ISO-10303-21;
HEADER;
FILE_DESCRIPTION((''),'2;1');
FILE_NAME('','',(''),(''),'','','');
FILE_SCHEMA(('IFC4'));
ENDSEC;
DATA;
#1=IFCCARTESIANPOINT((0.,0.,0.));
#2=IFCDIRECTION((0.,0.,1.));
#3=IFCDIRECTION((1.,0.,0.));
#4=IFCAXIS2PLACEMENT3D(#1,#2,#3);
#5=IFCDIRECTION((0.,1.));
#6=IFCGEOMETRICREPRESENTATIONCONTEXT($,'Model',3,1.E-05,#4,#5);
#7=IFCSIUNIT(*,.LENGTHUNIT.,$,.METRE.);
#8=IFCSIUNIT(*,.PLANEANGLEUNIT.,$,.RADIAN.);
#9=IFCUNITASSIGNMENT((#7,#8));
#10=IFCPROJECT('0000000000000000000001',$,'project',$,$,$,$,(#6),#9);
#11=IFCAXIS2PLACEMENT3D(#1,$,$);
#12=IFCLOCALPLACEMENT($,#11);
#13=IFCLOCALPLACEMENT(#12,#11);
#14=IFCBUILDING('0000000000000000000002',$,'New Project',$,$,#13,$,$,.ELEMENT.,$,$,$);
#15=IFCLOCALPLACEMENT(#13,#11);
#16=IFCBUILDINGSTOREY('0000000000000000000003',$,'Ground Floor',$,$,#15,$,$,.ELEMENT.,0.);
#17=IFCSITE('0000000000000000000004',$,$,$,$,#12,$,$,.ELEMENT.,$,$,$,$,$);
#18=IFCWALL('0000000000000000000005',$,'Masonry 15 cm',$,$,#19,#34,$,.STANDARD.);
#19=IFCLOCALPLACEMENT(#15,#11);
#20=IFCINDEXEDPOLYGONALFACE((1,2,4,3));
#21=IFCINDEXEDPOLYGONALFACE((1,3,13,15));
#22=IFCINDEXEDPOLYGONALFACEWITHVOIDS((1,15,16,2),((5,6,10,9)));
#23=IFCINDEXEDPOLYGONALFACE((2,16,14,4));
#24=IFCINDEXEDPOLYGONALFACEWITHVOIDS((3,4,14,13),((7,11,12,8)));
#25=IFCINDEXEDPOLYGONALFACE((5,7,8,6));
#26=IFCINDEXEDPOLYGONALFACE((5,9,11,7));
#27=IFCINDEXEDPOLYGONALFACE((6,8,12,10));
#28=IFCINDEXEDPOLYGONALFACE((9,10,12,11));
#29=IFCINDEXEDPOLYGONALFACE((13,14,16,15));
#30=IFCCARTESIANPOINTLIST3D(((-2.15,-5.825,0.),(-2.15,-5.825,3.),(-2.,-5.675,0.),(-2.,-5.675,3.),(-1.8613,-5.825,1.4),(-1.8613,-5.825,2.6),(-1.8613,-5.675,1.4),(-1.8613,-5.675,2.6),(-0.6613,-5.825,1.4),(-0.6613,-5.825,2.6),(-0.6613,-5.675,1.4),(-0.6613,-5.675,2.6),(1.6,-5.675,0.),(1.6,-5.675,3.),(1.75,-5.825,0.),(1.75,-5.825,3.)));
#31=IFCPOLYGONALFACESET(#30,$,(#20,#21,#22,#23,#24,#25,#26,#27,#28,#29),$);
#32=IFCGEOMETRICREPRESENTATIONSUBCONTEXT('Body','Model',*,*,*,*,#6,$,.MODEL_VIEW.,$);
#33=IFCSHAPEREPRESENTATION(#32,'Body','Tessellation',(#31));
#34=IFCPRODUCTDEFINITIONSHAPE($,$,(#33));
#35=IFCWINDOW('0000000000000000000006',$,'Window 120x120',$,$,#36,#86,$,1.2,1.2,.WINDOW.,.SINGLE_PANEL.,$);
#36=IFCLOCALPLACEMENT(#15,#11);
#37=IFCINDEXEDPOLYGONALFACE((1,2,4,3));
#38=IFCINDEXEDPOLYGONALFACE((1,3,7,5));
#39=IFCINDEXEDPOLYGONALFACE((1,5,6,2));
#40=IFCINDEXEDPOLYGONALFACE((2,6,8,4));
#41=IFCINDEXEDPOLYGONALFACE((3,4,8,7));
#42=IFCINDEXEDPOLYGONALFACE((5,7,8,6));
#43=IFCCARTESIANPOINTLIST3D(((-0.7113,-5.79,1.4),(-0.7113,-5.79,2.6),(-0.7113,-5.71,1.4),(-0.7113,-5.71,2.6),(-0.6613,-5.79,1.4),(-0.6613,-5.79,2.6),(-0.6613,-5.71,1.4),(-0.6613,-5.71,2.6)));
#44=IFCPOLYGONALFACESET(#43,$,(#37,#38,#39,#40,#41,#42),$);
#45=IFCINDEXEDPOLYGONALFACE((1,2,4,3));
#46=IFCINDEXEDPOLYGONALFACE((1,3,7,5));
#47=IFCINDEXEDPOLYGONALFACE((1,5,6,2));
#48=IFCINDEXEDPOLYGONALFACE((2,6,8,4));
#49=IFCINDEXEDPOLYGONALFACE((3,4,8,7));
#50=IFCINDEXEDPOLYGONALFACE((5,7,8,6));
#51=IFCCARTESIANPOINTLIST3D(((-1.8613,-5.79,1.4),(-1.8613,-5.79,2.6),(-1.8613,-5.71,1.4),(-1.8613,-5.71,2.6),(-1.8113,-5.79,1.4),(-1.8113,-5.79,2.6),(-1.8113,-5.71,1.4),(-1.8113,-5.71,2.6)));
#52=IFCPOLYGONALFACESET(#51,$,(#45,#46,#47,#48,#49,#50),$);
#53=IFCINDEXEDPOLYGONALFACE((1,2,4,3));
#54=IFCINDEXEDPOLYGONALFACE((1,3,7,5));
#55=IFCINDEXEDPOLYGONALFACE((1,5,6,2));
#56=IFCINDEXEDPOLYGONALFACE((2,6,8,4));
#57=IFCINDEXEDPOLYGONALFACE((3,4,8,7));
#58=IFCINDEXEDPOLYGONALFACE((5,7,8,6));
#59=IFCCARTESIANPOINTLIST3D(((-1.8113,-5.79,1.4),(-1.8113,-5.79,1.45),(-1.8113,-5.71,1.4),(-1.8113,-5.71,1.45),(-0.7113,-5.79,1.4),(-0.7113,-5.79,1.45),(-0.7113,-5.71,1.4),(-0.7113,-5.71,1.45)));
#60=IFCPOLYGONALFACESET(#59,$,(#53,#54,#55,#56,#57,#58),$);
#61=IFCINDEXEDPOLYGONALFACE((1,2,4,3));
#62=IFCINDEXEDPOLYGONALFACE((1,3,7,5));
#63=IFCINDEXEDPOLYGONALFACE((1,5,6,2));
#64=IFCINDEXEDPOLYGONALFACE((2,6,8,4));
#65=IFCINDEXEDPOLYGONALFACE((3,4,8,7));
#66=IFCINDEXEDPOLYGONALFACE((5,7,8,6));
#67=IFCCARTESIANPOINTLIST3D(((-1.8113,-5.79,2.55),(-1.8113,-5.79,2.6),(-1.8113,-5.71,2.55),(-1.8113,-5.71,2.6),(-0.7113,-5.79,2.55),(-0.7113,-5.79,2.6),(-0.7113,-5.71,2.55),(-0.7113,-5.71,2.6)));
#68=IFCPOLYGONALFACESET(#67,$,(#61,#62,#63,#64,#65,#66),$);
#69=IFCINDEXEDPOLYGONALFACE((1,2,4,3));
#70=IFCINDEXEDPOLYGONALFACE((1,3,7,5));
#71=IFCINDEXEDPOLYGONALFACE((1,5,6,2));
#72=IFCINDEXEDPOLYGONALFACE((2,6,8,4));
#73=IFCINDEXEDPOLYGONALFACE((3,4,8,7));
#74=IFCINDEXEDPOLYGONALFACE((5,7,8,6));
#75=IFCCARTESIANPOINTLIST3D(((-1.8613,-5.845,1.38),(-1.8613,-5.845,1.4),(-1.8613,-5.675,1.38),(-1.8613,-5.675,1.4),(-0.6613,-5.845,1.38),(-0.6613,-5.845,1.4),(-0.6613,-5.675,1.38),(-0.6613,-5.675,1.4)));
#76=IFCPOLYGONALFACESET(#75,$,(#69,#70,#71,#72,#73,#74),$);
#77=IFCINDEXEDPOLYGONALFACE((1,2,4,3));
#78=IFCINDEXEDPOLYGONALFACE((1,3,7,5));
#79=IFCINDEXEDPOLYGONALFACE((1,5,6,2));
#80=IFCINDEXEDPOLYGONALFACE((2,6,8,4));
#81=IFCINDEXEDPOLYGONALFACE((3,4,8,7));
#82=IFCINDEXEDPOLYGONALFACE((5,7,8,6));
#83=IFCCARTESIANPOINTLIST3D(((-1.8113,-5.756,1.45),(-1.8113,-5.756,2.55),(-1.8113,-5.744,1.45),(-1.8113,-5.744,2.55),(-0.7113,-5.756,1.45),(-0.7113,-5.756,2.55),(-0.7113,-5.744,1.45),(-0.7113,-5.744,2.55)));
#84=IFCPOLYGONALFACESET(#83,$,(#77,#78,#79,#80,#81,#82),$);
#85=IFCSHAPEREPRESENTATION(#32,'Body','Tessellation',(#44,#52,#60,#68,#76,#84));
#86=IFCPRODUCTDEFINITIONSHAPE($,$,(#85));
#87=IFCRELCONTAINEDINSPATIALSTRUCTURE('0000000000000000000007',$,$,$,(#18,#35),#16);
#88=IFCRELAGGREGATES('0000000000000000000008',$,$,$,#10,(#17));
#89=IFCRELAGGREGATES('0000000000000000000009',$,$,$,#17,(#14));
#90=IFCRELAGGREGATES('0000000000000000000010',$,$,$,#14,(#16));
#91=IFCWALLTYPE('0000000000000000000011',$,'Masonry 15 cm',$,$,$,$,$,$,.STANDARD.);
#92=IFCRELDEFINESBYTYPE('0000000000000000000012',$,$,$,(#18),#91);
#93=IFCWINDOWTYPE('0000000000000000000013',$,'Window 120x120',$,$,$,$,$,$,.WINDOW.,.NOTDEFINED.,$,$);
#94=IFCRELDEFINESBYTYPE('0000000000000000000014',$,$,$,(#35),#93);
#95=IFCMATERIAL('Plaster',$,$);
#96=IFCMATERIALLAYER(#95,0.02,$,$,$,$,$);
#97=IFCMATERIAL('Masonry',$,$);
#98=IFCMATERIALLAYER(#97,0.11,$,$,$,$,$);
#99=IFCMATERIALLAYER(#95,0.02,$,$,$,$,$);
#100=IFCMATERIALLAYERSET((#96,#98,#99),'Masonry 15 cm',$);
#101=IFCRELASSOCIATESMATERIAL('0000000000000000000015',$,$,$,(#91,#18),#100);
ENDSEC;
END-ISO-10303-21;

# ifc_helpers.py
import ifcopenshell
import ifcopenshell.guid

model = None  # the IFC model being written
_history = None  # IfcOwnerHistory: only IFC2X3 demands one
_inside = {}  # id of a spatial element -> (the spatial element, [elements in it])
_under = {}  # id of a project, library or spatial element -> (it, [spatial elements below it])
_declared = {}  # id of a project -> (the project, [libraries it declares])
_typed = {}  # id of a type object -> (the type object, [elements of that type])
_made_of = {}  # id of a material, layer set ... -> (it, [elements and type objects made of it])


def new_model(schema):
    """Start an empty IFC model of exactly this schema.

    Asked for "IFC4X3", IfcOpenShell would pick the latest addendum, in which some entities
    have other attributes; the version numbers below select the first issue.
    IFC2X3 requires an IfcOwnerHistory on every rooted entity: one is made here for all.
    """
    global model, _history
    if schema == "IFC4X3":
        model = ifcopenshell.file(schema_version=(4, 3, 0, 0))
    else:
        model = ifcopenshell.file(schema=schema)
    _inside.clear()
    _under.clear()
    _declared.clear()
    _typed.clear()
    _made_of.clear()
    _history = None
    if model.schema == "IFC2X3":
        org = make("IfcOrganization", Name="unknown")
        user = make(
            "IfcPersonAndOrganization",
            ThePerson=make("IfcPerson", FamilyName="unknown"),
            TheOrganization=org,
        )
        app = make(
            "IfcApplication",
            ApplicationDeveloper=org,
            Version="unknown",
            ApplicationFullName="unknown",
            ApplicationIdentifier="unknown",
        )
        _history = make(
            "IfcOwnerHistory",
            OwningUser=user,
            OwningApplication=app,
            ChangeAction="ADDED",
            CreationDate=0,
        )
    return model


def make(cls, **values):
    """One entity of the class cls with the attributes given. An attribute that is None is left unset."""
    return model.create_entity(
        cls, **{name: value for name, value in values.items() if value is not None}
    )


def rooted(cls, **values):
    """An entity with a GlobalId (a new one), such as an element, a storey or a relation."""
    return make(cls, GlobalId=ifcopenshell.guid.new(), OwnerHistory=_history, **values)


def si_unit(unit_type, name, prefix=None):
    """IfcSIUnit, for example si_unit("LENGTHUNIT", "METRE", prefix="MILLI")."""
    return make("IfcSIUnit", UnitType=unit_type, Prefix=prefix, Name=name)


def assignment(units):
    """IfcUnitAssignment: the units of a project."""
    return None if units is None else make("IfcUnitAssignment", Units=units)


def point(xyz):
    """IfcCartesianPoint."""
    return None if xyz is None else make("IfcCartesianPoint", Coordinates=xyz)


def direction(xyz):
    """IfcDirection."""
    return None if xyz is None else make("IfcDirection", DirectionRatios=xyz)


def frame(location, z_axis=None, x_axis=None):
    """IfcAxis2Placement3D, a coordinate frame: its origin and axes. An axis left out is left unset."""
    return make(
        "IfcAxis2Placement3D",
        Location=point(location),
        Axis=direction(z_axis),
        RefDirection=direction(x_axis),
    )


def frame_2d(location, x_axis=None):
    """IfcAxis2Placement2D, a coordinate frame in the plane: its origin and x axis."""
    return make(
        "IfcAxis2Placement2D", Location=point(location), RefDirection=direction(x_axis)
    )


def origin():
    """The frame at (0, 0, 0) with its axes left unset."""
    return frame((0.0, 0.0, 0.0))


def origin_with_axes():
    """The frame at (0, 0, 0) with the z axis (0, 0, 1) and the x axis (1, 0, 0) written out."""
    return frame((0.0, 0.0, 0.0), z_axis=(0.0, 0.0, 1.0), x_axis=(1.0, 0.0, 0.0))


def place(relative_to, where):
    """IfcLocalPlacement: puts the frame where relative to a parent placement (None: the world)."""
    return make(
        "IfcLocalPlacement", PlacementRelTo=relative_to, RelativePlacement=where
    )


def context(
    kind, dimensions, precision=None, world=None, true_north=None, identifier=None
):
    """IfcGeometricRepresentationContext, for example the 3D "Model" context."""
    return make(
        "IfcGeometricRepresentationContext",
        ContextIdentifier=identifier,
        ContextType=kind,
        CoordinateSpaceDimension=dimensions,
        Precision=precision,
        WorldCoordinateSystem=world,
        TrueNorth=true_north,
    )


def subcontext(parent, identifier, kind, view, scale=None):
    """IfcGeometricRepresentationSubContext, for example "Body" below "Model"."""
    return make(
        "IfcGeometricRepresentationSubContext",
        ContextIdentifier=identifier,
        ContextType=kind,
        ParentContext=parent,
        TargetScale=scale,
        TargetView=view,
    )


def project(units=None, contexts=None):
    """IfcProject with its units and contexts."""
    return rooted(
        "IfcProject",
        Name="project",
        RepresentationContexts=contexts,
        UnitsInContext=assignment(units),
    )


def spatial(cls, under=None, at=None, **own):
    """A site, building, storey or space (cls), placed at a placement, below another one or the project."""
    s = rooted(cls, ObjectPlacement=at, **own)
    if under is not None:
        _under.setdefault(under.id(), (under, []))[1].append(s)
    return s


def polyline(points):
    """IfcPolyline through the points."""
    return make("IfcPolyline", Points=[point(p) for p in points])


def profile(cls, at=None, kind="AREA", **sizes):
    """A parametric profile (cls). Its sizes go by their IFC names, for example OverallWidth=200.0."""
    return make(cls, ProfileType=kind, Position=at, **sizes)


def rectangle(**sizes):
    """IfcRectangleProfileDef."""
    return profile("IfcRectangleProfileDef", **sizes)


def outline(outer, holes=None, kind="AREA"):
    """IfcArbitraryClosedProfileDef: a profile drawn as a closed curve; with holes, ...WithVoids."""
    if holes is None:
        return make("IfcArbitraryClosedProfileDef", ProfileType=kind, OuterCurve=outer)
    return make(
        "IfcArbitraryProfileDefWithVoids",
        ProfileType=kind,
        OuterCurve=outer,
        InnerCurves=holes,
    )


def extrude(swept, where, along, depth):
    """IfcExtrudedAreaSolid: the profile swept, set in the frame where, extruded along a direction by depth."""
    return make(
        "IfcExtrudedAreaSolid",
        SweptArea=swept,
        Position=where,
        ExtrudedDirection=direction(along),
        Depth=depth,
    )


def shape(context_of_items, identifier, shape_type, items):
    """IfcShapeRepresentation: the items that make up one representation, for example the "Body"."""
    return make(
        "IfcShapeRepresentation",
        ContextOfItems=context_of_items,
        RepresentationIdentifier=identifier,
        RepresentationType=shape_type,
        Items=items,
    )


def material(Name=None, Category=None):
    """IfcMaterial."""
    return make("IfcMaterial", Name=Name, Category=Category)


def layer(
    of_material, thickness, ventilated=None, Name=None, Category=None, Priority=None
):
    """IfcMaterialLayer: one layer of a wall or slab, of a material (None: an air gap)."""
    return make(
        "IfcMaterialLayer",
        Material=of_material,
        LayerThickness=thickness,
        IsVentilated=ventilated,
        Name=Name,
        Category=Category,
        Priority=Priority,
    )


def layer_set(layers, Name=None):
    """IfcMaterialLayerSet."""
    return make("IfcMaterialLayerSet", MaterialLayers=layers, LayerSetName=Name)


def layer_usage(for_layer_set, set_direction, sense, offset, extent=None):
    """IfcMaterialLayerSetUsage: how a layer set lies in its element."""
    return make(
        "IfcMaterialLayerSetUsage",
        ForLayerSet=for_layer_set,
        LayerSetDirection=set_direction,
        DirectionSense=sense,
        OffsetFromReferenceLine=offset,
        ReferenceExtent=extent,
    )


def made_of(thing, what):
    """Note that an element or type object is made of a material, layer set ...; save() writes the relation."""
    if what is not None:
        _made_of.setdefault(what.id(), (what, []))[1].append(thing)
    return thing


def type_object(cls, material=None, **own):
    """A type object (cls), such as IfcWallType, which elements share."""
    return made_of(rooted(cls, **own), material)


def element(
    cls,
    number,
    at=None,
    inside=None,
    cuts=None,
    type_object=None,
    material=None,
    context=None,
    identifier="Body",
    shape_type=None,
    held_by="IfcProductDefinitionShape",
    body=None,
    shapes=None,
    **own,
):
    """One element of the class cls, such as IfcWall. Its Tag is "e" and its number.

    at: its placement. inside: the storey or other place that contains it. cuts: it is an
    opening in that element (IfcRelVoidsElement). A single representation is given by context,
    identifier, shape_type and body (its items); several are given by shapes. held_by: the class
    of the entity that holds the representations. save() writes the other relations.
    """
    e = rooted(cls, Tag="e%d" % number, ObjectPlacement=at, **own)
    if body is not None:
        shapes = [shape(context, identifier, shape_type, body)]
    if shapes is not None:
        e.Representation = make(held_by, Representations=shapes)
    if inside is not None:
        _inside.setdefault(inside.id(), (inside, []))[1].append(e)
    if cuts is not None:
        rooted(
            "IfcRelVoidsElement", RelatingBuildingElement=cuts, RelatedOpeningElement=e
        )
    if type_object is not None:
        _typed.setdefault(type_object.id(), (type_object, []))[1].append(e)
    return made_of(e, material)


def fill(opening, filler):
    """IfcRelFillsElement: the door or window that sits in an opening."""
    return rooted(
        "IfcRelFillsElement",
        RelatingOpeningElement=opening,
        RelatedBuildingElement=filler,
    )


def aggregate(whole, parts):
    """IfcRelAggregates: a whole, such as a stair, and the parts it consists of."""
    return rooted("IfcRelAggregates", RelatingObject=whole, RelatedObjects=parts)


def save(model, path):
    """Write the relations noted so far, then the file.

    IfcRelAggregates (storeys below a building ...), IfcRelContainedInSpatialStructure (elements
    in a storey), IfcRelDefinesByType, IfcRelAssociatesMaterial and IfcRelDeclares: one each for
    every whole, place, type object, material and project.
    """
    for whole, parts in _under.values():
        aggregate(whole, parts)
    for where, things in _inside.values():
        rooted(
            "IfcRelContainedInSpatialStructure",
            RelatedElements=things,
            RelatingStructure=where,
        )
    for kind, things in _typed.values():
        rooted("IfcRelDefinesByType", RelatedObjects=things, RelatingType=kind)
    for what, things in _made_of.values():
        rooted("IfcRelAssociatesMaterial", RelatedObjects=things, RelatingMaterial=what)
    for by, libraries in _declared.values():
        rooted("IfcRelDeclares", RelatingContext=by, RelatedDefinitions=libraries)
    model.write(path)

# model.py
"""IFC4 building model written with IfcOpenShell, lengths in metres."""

from ifc_helpers import new_model, si_unit, direction, frame, frame_2d, origin, origin_with_axes, place, context, subcontext, project, spatial, polyline, rectangle, outline, extrude, material, layer, layer_set, layer_usage, type_object, element, fill, save


model = new_model("IFC4")

# Units and contexts
model_context = context("Model", 3, precision=1e-05, world=origin_with_axes(), true_north=direction((0.0, 1.0)))
body_context = subcontext(model_context, "Body", "Model", "MODEL_VIEW")
ifc_project = project(units=[si_unit("LENGTHUNIT", "METRE"), si_unit("PLANEANGLEUNIT", "RADIAN")], contexts=[model_context])

# Site, building, storey
site_placement = place(None, origin())
site = spatial("IfcSite", under=ifc_project, at=site_placement, CompositionType="ELEMENT")
building_placement = place(site_placement, origin())
building = spatial("IfcBuilding", under=site, at=building_placement, Name="New Project", CompositionType="ELEMENT")
storey_placement = place(building_placement, origin())
storey = spatial("IfcBuildingStorey", under=building, at=storey_placement, Name="Ground Floor", CompositionType="ELEMENT", Elevation=0.0)

# Shared definitions
ifc_material_1 = material(Name="Plaster")
ifc_layer_1 = layer(ifc_material_1, 0.02)
ifc_material_2 = material(Name="Masonry")
ifc_layer_2 = layer(ifc_material_2, 0.11)
ifc_layer_3 = layer(ifc_material_1, 0.02)
ifc_layer_set_1 = layer_set([ifc_layer_1, ifc_layer_2, ifc_layer_3], Name="Masonry 15 cm")
ifc_layer_usage_1 = layer_usage(ifc_layer_set_1, "AXIS2", "NEGATIVE", 0.075)
wall_type = type_object("IfcWallType", Name="Masonry 15 cm", PredefinedType="STANDARD", material=ifc_layer_set_1)
window_type = type_object("IfcWindowType", Name="Window 120x120", PartitioningType="NOTDEFINED", PredefinedType="WINDOW")

# Wall, opening, window
wall_1_placement = place(storey_placement, frame((1.675, -5.75, 0.0), z_axis=(0.0, 0.0, 1.0), x_axis=(-1.0, 0.0, 0.0)))
wall_1 = element("IfcWall", 1, at=wall_1_placement, inside=storey, type_object=wall_type, material=ifc_layer_usage_1, Name="Masonry 15 cm", PredefinedType="STANDARD", context=body_context, shape_type="SweptSolid", body=[
    extrude(outline(polyline([(0.075, -0.075), (3.675, -0.075), (3.825, 0.075), (-0.075, 0.075), (0.075, -0.075)])), origin(), (0.0, 0.0, 1.0), 3.0),
])
opening_1_placement = place(wall_1_placement, frame((2.3363, 0.0, 1.4)))
opening_1 = element("IfcOpeningElement", 2, at=opening_1_placement, cuts=wall_1, PredefinedType="OPENING", context=body_context, shape_type="SweptSolid", body=[
    extrude(rectangle(XDim=1.2, YDim=0.25, at=frame_2d((0.6, 0.0))), origin(), (0.0, 0.0, 1.0), 1.2),
])
window_1_placement = place(opening_1_placement, origin())
window_1 = element("IfcWindow", 3, at=window_1_placement, inside=storey, type_object=window_type, Name="Window 120x120", OverallHeight=1.2, OverallWidth=1.2, PartitioningType="SINGLE_PANEL", PredefinedType="WINDOW", context=body_context, shape_type="SweptSolid", body=[
    extrude(outline(polyline([(0.0, -0.04), (0.05, -0.04), (0.05, 0.04), (0.0, 0.04), (0.0, -0.04)])), origin(), (0.0, 0.0, 1.0), 1.2),
    extrude(outline(polyline([(1.15, -0.04), (1.2, -0.04), (1.2, 0.04), (1.15, 0.04), (1.15, -0.04)])), origin(), (0.0, 0.0, 1.0), 1.2),
    extrude(outline(polyline([(0.05, -0.04), (1.15, -0.04), (1.15, 0.04), (0.05, 0.04), (0.05, -0.04)])), origin(), (0.0, 0.0, 1.0), 0.05),
    extrude(outline(polyline([(0.05, -0.04), (1.15, -0.04), (1.15, 0.04), (0.05, 0.04), (0.05, -0.04)])), frame((0.0, 0.0, 1.15)), (0.0, 0.0, 1.0), 0.05),
    extrude(outline(polyline([(0.0, -0.075), (1.2, -0.075), (1.2, 0.095), (0.0, 0.095), (0.0, -0.075)])), frame((0.0, 0.0, -0.02)), (0.0, 0.0, 1.0), 0.02),
    extrude(outline(polyline([(0.05, -0.006), (1.15, -0.006), (1.15, 0.006), (0.05, 0.006), (0.05, -0.006)])), frame((0.0, 0.0, 0.05)), (0.0, 0.0, 1.0), 1.1),
])
fill(opening_1, window_1)

save(model, "model.ifc")
